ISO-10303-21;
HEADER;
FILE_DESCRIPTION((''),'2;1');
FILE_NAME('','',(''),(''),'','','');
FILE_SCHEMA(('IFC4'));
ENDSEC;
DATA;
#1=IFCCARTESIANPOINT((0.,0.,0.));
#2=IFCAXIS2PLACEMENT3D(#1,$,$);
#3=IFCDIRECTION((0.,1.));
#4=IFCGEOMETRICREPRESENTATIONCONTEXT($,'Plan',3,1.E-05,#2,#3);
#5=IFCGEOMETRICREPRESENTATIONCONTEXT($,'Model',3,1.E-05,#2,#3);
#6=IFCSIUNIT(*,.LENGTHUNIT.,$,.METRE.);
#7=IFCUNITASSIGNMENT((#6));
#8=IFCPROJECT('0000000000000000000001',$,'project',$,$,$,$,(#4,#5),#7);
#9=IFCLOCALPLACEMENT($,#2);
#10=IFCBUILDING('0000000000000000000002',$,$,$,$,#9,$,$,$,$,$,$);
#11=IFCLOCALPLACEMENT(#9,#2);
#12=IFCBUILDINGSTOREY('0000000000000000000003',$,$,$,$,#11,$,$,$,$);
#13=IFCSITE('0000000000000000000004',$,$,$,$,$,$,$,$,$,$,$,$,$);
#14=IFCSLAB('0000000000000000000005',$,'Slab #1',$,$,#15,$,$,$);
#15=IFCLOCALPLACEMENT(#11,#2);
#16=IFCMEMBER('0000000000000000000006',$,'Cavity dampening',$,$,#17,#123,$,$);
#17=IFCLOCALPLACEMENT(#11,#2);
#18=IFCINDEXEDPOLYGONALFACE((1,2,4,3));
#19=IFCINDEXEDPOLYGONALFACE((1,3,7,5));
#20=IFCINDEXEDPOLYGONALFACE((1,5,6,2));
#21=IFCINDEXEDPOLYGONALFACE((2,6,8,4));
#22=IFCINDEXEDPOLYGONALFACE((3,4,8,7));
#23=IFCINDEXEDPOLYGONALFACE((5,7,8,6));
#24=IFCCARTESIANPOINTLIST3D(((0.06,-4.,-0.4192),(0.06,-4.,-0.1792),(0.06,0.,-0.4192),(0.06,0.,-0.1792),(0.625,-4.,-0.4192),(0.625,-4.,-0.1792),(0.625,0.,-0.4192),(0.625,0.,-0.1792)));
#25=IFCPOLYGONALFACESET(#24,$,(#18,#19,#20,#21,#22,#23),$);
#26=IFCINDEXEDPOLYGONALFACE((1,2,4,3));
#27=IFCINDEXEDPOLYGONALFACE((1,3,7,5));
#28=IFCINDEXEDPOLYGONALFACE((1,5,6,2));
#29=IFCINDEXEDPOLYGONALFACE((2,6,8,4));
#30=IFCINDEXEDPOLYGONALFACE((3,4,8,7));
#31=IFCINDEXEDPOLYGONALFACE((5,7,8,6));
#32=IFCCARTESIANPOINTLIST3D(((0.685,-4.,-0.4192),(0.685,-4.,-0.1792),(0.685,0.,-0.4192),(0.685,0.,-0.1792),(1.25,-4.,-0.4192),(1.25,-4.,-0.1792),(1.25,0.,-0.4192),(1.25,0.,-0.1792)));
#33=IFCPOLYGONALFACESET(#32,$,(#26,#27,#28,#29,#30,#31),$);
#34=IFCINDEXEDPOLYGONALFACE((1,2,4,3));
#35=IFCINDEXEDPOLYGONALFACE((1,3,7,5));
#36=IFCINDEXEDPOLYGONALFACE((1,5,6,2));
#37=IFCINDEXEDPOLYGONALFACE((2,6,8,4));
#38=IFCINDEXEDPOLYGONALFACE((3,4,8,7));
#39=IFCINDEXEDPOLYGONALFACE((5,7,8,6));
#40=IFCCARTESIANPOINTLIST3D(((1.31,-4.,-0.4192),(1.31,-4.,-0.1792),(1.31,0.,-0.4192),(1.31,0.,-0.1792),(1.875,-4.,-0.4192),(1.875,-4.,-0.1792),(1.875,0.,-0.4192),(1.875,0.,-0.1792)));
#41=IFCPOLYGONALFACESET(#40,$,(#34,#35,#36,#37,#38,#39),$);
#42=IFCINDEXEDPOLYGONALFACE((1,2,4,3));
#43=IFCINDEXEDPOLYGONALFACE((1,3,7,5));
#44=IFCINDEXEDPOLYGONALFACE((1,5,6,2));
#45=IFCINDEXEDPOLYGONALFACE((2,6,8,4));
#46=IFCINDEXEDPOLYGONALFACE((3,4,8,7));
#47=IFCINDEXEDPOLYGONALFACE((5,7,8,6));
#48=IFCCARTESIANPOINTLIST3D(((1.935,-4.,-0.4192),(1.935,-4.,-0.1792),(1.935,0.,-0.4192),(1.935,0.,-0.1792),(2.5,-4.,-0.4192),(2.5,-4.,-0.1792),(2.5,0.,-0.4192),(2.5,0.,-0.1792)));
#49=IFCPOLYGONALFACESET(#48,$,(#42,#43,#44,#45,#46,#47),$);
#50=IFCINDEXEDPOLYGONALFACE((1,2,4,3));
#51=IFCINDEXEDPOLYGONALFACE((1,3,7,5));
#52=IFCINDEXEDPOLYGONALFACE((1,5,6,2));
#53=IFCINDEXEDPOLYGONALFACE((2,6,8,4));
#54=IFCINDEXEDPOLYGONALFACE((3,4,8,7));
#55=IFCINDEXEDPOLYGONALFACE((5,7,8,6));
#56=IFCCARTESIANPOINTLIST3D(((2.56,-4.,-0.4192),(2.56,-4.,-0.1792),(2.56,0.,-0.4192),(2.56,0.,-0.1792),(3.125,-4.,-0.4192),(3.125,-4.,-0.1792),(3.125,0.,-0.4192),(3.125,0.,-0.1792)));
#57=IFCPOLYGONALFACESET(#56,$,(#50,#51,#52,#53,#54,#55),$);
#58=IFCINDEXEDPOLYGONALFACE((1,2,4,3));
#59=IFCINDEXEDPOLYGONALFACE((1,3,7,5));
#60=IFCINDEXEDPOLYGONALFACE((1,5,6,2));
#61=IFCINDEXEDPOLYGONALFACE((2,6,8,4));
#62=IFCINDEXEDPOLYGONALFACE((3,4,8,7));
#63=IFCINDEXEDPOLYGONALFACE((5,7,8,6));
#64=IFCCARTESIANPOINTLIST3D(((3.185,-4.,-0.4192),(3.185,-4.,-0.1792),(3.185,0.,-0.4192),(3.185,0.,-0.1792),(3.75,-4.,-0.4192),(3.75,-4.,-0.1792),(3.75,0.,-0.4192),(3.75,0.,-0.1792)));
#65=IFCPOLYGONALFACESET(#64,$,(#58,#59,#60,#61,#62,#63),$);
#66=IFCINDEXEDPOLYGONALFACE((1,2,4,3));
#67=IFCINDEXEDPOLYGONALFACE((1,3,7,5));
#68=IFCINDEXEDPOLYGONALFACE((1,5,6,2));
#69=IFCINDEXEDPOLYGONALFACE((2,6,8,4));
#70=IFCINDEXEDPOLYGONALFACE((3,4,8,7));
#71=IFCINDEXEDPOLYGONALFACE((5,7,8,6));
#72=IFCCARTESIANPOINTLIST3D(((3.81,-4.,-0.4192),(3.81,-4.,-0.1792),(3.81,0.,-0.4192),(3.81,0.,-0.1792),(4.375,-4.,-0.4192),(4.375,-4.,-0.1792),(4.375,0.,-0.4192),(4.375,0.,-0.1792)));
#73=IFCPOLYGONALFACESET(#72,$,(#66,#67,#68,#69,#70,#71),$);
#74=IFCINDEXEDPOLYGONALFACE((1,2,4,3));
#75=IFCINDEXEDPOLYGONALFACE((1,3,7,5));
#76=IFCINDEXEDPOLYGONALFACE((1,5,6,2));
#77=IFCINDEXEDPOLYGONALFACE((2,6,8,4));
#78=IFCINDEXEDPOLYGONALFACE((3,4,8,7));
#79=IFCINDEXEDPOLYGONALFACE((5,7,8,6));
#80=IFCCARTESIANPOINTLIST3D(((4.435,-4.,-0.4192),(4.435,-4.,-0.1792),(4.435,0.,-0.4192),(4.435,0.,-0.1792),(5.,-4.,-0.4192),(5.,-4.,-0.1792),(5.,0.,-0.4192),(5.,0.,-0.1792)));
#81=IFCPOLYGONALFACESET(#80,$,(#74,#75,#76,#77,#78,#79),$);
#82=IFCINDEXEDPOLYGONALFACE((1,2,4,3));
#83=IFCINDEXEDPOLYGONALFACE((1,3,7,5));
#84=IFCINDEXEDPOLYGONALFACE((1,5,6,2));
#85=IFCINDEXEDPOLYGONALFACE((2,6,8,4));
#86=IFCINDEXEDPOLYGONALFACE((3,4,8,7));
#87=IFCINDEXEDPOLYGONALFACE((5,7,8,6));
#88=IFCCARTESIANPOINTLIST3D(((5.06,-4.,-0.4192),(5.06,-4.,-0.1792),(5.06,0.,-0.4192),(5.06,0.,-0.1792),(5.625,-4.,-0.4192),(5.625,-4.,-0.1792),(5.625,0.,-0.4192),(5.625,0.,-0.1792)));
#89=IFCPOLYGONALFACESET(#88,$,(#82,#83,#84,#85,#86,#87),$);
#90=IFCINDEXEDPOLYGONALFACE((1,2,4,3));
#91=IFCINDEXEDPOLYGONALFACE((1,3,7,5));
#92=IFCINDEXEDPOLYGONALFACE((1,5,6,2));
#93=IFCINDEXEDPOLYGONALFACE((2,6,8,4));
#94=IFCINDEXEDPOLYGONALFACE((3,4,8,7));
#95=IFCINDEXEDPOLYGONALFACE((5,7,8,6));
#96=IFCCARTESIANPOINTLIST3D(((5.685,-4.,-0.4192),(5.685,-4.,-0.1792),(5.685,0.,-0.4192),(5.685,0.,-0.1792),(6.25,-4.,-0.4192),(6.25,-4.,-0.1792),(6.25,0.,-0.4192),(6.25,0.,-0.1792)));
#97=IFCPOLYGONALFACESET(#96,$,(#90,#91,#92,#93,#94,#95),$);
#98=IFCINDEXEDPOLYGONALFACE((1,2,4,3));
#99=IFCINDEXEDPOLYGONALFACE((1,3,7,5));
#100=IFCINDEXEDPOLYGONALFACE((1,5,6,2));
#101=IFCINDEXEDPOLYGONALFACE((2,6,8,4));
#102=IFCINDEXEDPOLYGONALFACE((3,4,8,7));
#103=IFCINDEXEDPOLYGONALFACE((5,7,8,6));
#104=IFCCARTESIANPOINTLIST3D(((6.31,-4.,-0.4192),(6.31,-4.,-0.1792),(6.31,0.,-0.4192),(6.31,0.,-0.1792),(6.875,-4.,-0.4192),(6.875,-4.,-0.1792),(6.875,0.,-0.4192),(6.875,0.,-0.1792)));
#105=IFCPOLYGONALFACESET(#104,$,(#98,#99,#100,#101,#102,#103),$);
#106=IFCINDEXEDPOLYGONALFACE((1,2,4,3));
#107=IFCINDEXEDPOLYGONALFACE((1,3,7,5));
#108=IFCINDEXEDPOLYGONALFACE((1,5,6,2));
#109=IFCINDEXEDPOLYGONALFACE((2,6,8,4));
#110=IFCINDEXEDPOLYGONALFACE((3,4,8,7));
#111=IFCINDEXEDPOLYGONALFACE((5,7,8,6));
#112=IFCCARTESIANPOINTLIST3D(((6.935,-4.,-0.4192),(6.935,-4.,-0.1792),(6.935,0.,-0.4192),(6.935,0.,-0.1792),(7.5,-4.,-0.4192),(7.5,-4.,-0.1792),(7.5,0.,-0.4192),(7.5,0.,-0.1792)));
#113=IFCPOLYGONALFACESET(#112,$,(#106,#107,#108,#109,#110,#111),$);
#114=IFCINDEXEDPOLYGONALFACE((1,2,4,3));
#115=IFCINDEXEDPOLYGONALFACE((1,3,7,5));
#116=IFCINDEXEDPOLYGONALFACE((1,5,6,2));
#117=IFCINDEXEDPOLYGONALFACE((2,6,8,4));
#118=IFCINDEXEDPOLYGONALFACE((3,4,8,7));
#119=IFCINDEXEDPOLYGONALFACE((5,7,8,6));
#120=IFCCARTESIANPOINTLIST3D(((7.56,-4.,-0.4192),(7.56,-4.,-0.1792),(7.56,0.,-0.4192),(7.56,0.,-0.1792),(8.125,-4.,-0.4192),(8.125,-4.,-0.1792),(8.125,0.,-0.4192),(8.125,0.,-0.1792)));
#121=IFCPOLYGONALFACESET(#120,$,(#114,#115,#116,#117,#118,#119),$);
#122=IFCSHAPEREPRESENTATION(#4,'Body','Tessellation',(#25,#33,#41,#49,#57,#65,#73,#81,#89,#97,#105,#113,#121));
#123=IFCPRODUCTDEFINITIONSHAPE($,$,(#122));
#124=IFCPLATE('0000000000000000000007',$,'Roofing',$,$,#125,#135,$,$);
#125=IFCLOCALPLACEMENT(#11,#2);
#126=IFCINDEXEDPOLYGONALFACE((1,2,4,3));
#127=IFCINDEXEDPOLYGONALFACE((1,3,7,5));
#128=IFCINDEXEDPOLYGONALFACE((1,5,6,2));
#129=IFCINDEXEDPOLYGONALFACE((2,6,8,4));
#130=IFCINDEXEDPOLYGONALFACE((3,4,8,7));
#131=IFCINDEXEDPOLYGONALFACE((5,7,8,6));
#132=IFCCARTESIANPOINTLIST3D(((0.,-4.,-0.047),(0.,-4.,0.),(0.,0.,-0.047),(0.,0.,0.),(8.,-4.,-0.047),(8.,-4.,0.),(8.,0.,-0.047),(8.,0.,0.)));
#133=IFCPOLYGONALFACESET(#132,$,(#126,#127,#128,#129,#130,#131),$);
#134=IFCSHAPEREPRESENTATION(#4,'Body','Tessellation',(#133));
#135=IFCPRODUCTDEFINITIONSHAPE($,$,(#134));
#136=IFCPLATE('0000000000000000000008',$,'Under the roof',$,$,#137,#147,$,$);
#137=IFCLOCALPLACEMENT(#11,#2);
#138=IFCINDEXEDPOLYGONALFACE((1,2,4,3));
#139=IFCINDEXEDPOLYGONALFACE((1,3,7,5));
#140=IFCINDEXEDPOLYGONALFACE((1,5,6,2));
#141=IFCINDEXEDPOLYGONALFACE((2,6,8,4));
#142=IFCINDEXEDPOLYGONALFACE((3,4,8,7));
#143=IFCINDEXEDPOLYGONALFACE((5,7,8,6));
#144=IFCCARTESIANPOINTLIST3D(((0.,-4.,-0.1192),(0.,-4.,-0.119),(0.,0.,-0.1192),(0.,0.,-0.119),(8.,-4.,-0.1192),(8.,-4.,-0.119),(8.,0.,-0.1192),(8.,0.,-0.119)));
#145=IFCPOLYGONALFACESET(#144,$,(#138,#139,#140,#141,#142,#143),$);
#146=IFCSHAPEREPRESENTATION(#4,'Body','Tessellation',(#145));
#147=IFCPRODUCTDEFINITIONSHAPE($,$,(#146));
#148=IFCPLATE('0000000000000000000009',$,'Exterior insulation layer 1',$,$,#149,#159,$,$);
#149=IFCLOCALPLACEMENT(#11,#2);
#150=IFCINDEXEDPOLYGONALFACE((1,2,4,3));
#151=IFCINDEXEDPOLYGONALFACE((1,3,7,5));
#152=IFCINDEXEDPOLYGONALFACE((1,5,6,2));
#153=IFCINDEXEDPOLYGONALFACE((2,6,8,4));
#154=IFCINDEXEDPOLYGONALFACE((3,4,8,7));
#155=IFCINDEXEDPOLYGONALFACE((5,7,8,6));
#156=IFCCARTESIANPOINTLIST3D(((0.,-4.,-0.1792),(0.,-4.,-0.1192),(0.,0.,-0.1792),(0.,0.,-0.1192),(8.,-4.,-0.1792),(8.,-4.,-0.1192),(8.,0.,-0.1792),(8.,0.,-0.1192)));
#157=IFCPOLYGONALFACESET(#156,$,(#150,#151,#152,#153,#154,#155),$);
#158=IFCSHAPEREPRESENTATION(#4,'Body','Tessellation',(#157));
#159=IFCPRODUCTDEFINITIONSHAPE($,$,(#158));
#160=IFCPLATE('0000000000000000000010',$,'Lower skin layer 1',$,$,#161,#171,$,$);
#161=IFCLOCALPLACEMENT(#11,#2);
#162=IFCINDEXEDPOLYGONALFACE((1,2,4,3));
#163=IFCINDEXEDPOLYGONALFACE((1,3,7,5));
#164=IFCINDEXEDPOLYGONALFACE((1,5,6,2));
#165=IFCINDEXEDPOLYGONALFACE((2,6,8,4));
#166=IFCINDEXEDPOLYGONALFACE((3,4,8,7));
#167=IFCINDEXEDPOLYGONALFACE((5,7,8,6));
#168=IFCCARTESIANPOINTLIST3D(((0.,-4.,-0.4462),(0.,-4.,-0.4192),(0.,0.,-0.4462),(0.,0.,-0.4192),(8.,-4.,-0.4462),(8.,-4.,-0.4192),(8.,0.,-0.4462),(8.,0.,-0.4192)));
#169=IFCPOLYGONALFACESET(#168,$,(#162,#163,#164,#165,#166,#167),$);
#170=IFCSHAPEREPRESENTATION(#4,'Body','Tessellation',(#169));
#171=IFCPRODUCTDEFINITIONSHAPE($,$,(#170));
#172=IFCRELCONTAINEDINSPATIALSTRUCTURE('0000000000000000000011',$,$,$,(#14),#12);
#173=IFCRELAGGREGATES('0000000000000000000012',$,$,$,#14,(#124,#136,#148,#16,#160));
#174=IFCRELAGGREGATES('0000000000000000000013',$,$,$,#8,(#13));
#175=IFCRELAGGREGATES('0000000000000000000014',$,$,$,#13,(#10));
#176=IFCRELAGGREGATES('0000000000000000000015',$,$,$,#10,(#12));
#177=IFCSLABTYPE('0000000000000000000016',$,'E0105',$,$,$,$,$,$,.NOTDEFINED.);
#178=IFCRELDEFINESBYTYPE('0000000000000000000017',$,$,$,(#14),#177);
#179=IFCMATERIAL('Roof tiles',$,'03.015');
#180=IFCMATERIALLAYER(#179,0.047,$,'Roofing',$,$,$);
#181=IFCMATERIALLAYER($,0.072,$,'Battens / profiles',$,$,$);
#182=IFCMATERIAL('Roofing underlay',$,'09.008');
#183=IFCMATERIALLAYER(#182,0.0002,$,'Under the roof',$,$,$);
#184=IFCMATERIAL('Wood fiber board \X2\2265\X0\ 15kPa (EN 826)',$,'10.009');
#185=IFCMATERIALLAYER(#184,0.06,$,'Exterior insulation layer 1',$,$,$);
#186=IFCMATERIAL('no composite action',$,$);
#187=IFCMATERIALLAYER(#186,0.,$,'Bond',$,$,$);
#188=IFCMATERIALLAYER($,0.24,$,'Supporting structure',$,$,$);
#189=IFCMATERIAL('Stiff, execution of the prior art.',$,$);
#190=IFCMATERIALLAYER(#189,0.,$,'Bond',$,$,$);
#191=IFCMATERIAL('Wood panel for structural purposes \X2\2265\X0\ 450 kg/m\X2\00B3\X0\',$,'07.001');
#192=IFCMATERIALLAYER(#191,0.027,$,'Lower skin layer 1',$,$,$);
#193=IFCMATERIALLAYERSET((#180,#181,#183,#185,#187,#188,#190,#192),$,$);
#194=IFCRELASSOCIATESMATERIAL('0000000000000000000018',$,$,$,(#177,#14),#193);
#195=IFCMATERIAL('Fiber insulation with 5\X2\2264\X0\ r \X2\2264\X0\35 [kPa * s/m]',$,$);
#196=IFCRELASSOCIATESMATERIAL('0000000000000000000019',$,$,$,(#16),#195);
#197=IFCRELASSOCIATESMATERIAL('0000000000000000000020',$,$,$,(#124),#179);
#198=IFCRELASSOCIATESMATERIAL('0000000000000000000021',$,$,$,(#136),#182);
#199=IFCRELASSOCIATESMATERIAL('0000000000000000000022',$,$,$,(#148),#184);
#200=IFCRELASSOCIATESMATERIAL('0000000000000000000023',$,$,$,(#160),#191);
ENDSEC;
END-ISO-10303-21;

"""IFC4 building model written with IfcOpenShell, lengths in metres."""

from ifc_helpers import new_model, si_unit, direction, frame, frame_2d, origin, origin_with_axes, place, context, project, spatial, rectangle, extrude, material, layer, layer_set, type_object, element, aggregate, save


model = new_model("IFC4")

# Units and contexts
plan_context = context("Plan", 3, precision=1e-05, world=origin(), true_north=direction((0.0, 1.0)))
model_context = context("Model", 3, precision=1e-05, world=origin(), true_north=direction((0.0, 1.0)))
ifc_project = project(units=[si_unit("LENGTHUNIT", "METRE")], contexts=[plan_context, model_context])

# Site, building, storey
site = spatial("IfcSite", under=ifc_project)
building_placement = place(None, origin())
building = spatial("IfcBuilding", under=site, at=building_placement)
storey_placement = place(building_placement, origin())
storey = spatial("IfcBuildingStorey", under=building, at=storey_placement)

# Slab, member, plates
ifc_material_1 = material(Name="Roof tiles", Category="03.015")
ifc_layer_1 = layer(ifc_material_1, 0.047, Name="Roofing")
ifc_layer_2 = layer(None, 0.072, Name="Battens / profiles")
ifc_material_2 = material(Name="Roofing underlay", Category="09.008")
ifc_layer_3 = layer(ifc_material_2, 0.0002, Name="Under the roof")
ifc_material_3 = material(Name="Wood fiber board ≥ 15kPa (EN 826)", Category="10.009")
ifc_layer_4 = layer(ifc_material_3, 0.06, Name="Exterior insulation layer 1")
ifc_material_4 = material(Name="no composite action")
ifc_layer_5 = layer(ifc_material_4, 0.0, Name="Bond")
ifc_layer_6 = layer(None, 0.24, Name="Supporting structure")
ifc_material_5 = material(Name="Stiff, execution of the prior art.")
ifc_layer_7 = layer(ifc_material_5, 0.0, Name="Bond")
ifc_material_6 = material(Name="Wood panel for structural purposes ≥ 450 kg/m³", Category="07.001")
ifc_layer_8 = layer(ifc_material_6, 0.027, Name="Lower skin layer 1")
ifc_layer_set = layer_set([ifc_layer_1, ifc_layer_2, ifc_layer_3, ifc_layer_4, ifc_layer_5, ifc_layer_6, ifc_layer_7, ifc_layer_8])
slab_type = type_object("IfcSlabType", Name="E0105", PredefinedType="NOTDEFINED", material=ifc_layer_set)
slab_placement = place(None, frame((0.0, 0.0, 0.0), z_axis=(0.0, 0.0, -1.0), x_axis=(1.0, 0.0, 0.0)))
slab = element("IfcSlab", 1, at=slab_placement, inside=storey, type_object=slab_type, material=ifc_layer_set, Name="Slab #1")
ifc_material_7 = material(Name="Fiber insulation with 5≤ r ≤35 [kPa * s/m]")
member_1_placement = place(slab_placement, origin())
member_1 = element("IfcMember", 2, at=member_1_placement, material=ifc_material_7, Name="Cavity dampening", context=plan_context, shape_type="SweptSolid", body=[
    extrude(rectangle(XDim=0.565, YDim=0.24, at=frame_2d((0.2825, 0.12), x_axis=(1.0, 0.0))), frame((0.06, 4.0, 0.1792), z_axis=(0.0, -1.0, 0.0), x_axis=(1.0, 0.0, 0.0)), (0.0, 0.0, 1.0), 4.0),
    extrude(rectangle(XDim=0.565, YDim=0.24, at=frame_2d((0.2825, 0.12), x_axis=(1.0, 0.0))), frame((0.685, 4.0, 0.1792), z_axis=(0.0, -1.0, 0.0), x_axis=(1.0, 0.0, 0.0)), (0.0, 0.0, 1.0), 4.0),
    extrude(rectangle(XDim=0.565, YDim=0.24, at=frame_2d((0.2825, 0.12), x_axis=(1.0, 0.0))), frame((1.31, 4.0, 0.1792), z_axis=(0.0, -1.0, 0.0), x_axis=(1.0, 0.0, 0.0)), (0.0, 0.0, 1.0), 4.0),
    extrude(rectangle(XDim=0.565, YDim=0.24, at=frame_2d((0.2825, 0.12), x_axis=(1.0, 0.0))), frame((1.935, 4.0, 0.1792), z_axis=(0.0, -1.0, 0.0), x_axis=(1.0, 0.0, 0.0)), (0.0, 0.0, 1.0), 4.0),
    extrude(rectangle(XDim=0.565, YDim=0.24, at=frame_2d((0.2825, 0.12), x_axis=(1.0, 0.0))), frame((2.56, 4.0, 0.1792), z_axis=(0.0, -1.0, 0.0), x_axis=(1.0, 0.0, 0.0)), (0.0, 0.0, 1.0), 4.0),
    extrude(rectangle(XDim=0.565, YDim=0.24, at=frame_2d((0.2825, 0.12), x_axis=(1.0, 0.0))), frame((3.185, 4.0, 0.1792), z_axis=(0.0, -1.0, 0.0), x_axis=(1.0, 0.0, 0.0)), (0.0, 0.0, 1.0), 4.0),
    extrude(rectangle(XDim=0.565, YDim=0.24, at=frame_2d((0.2825, 0.12), x_axis=(1.0, 0.0))), frame((3.81, 4.0, 0.1792), z_axis=(0.0, -1.0, 0.0), x_axis=(1.0, 0.0, 0.0)), (0.0, 0.0, 1.0), 4.0),
    extrude(rectangle(XDim=0.565, YDim=0.24, at=frame_2d((0.2825, 0.12), x_axis=(1.0, 0.0))), frame((4.435, 4.0, 0.1792), z_axis=(0.0, -1.0, 0.0), x_axis=(1.0, 0.0, 0.0)), (0.0, 0.0, 1.0), 4.0),
    extrude(rectangle(XDim=0.565, YDim=0.24, at=frame_2d((0.2825, 0.12), x_axis=(1.0, 0.0))), frame((5.06, 4.0, 0.1792), z_axis=(0.0, -1.0, 0.0), x_axis=(1.0, 0.0, 0.0)), (0.0, 0.0, 1.0), 4.0),
    extrude(rectangle(XDim=0.565, YDim=0.24, at=frame_2d((0.2825, 0.12), x_axis=(1.0, 0.0))), frame((5.685, 4.0, 0.1792), z_axis=(0.0, -1.0, 0.0), x_axis=(1.0, 0.0, 0.0)), (0.0, 0.0, 1.0), 4.0),
    extrude(rectangle(XDim=0.565, YDim=0.24, at=frame_2d((0.2825, 0.12), x_axis=(1.0, 0.0))), frame((6.31, 4.0, 0.1792), z_axis=(0.0, -1.0, 0.0), x_axis=(1.0, 0.0, 0.0)), (0.0, 0.0, 1.0), 4.0),
    extrude(rectangle(XDim=0.565, YDim=0.24, at=frame_2d((0.2825, 0.12), x_axis=(1.0, 0.0))), frame((6.935, 4.0, 0.1792), z_axis=(0.0, -1.0, 0.0), x_axis=(1.0, 0.0, 0.0)), (0.0, 0.0, 1.0), 4.0),
    extrude(rectangle(XDim=0.565, YDim=0.24, at=frame_2d((0.2825, 0.12), x_axis=(1.0, 0.0))), frame((7.56, 4.0, 0.1792), z_axis=(0.0, -1.0, 0.0), x_axis=(1.0, 0.0, 0.0)), (0.0, 0.0, 1.0), 4.0),
])
plate_1_placement = place(slab_placement, origin())
plate_1 = element("IfcPlate", 3, at=plate_1_placement, material=ifc_material_1, Name="Roofing", context=plan_context, shape_type="SweptSolid", body=[
    extrude(rectangle(XDim=8.0, YDim=4.0, at=frame_2d((4.0, 2.0), x_axis=(1.0, 0.0))), origin_with_axes(), (0.0, 0.0, 1.0), 0.047),
])
plate_2_placement = place(slab_placement, origin())
plate_2 = element("IfcPlate", 4, at=plate_2_placement, material=ifc_material_2, Name="Under the roof", context=plan_context, shape_type="SweptSolid", body=[
    extrude(rectangle(XDim=8.0, YDim=4.0, at=frame_2d((4.0, 2.0), x_axis=(1.0, 0.0))), frame((0.0, 0.0, 0.119), z_axis=(0.0, 0.0, 1.0), x_axis=(1.0, 0.0, 0.0)), (0.0, 0.0, 1.0), 0.0002),
])
plate_3_placement = place(slab_placement, origin())
plate_3 = element("IfcPlate", 5, at=plate_3_placement, material=ifc_material_3, Name="Exterior insulation layer 1", context=plan_context, shape_type="SweptSolid", body=[
    extrude(rectangle(XDim=8.0, YDim=4.0, at=frame_2d((4.0, 2.0), x_axis=(1.0, 0.0))), frame((0.0, 0.0, 0.1192), z_axis=(0.0, 0.0, 1.0), x_axis=(1.0, 0.0, 0.0)), (0.0, 0.0, 1.0), 0.06),
])
plate_4_placement = place(slab_placement, origin())
plate_4 = element("IfcPlate", 6, at=plate_4_placement, material=ifc_material_6, Name="Lower skin layer 1", context=plan_context, shape_type="SweptSolid", body=[
    extrude(rectangle(XDim=8.0, YDim=4.0, at=frame_2d((4.0, 2.0), x_axis=(1.0, 0.0))), frame((0.0, 0.0, 0.4192), z_axis=(0.0, 0.0, 1.0), x_axis=(1.0, 0.0, 0.0)), (0.0, 0.0, 1.0), 0.027),
])
aggregate(slab, [plate_1, plate_2, plate_3, member_1, plate_4])

save(model, "model.ifc")
